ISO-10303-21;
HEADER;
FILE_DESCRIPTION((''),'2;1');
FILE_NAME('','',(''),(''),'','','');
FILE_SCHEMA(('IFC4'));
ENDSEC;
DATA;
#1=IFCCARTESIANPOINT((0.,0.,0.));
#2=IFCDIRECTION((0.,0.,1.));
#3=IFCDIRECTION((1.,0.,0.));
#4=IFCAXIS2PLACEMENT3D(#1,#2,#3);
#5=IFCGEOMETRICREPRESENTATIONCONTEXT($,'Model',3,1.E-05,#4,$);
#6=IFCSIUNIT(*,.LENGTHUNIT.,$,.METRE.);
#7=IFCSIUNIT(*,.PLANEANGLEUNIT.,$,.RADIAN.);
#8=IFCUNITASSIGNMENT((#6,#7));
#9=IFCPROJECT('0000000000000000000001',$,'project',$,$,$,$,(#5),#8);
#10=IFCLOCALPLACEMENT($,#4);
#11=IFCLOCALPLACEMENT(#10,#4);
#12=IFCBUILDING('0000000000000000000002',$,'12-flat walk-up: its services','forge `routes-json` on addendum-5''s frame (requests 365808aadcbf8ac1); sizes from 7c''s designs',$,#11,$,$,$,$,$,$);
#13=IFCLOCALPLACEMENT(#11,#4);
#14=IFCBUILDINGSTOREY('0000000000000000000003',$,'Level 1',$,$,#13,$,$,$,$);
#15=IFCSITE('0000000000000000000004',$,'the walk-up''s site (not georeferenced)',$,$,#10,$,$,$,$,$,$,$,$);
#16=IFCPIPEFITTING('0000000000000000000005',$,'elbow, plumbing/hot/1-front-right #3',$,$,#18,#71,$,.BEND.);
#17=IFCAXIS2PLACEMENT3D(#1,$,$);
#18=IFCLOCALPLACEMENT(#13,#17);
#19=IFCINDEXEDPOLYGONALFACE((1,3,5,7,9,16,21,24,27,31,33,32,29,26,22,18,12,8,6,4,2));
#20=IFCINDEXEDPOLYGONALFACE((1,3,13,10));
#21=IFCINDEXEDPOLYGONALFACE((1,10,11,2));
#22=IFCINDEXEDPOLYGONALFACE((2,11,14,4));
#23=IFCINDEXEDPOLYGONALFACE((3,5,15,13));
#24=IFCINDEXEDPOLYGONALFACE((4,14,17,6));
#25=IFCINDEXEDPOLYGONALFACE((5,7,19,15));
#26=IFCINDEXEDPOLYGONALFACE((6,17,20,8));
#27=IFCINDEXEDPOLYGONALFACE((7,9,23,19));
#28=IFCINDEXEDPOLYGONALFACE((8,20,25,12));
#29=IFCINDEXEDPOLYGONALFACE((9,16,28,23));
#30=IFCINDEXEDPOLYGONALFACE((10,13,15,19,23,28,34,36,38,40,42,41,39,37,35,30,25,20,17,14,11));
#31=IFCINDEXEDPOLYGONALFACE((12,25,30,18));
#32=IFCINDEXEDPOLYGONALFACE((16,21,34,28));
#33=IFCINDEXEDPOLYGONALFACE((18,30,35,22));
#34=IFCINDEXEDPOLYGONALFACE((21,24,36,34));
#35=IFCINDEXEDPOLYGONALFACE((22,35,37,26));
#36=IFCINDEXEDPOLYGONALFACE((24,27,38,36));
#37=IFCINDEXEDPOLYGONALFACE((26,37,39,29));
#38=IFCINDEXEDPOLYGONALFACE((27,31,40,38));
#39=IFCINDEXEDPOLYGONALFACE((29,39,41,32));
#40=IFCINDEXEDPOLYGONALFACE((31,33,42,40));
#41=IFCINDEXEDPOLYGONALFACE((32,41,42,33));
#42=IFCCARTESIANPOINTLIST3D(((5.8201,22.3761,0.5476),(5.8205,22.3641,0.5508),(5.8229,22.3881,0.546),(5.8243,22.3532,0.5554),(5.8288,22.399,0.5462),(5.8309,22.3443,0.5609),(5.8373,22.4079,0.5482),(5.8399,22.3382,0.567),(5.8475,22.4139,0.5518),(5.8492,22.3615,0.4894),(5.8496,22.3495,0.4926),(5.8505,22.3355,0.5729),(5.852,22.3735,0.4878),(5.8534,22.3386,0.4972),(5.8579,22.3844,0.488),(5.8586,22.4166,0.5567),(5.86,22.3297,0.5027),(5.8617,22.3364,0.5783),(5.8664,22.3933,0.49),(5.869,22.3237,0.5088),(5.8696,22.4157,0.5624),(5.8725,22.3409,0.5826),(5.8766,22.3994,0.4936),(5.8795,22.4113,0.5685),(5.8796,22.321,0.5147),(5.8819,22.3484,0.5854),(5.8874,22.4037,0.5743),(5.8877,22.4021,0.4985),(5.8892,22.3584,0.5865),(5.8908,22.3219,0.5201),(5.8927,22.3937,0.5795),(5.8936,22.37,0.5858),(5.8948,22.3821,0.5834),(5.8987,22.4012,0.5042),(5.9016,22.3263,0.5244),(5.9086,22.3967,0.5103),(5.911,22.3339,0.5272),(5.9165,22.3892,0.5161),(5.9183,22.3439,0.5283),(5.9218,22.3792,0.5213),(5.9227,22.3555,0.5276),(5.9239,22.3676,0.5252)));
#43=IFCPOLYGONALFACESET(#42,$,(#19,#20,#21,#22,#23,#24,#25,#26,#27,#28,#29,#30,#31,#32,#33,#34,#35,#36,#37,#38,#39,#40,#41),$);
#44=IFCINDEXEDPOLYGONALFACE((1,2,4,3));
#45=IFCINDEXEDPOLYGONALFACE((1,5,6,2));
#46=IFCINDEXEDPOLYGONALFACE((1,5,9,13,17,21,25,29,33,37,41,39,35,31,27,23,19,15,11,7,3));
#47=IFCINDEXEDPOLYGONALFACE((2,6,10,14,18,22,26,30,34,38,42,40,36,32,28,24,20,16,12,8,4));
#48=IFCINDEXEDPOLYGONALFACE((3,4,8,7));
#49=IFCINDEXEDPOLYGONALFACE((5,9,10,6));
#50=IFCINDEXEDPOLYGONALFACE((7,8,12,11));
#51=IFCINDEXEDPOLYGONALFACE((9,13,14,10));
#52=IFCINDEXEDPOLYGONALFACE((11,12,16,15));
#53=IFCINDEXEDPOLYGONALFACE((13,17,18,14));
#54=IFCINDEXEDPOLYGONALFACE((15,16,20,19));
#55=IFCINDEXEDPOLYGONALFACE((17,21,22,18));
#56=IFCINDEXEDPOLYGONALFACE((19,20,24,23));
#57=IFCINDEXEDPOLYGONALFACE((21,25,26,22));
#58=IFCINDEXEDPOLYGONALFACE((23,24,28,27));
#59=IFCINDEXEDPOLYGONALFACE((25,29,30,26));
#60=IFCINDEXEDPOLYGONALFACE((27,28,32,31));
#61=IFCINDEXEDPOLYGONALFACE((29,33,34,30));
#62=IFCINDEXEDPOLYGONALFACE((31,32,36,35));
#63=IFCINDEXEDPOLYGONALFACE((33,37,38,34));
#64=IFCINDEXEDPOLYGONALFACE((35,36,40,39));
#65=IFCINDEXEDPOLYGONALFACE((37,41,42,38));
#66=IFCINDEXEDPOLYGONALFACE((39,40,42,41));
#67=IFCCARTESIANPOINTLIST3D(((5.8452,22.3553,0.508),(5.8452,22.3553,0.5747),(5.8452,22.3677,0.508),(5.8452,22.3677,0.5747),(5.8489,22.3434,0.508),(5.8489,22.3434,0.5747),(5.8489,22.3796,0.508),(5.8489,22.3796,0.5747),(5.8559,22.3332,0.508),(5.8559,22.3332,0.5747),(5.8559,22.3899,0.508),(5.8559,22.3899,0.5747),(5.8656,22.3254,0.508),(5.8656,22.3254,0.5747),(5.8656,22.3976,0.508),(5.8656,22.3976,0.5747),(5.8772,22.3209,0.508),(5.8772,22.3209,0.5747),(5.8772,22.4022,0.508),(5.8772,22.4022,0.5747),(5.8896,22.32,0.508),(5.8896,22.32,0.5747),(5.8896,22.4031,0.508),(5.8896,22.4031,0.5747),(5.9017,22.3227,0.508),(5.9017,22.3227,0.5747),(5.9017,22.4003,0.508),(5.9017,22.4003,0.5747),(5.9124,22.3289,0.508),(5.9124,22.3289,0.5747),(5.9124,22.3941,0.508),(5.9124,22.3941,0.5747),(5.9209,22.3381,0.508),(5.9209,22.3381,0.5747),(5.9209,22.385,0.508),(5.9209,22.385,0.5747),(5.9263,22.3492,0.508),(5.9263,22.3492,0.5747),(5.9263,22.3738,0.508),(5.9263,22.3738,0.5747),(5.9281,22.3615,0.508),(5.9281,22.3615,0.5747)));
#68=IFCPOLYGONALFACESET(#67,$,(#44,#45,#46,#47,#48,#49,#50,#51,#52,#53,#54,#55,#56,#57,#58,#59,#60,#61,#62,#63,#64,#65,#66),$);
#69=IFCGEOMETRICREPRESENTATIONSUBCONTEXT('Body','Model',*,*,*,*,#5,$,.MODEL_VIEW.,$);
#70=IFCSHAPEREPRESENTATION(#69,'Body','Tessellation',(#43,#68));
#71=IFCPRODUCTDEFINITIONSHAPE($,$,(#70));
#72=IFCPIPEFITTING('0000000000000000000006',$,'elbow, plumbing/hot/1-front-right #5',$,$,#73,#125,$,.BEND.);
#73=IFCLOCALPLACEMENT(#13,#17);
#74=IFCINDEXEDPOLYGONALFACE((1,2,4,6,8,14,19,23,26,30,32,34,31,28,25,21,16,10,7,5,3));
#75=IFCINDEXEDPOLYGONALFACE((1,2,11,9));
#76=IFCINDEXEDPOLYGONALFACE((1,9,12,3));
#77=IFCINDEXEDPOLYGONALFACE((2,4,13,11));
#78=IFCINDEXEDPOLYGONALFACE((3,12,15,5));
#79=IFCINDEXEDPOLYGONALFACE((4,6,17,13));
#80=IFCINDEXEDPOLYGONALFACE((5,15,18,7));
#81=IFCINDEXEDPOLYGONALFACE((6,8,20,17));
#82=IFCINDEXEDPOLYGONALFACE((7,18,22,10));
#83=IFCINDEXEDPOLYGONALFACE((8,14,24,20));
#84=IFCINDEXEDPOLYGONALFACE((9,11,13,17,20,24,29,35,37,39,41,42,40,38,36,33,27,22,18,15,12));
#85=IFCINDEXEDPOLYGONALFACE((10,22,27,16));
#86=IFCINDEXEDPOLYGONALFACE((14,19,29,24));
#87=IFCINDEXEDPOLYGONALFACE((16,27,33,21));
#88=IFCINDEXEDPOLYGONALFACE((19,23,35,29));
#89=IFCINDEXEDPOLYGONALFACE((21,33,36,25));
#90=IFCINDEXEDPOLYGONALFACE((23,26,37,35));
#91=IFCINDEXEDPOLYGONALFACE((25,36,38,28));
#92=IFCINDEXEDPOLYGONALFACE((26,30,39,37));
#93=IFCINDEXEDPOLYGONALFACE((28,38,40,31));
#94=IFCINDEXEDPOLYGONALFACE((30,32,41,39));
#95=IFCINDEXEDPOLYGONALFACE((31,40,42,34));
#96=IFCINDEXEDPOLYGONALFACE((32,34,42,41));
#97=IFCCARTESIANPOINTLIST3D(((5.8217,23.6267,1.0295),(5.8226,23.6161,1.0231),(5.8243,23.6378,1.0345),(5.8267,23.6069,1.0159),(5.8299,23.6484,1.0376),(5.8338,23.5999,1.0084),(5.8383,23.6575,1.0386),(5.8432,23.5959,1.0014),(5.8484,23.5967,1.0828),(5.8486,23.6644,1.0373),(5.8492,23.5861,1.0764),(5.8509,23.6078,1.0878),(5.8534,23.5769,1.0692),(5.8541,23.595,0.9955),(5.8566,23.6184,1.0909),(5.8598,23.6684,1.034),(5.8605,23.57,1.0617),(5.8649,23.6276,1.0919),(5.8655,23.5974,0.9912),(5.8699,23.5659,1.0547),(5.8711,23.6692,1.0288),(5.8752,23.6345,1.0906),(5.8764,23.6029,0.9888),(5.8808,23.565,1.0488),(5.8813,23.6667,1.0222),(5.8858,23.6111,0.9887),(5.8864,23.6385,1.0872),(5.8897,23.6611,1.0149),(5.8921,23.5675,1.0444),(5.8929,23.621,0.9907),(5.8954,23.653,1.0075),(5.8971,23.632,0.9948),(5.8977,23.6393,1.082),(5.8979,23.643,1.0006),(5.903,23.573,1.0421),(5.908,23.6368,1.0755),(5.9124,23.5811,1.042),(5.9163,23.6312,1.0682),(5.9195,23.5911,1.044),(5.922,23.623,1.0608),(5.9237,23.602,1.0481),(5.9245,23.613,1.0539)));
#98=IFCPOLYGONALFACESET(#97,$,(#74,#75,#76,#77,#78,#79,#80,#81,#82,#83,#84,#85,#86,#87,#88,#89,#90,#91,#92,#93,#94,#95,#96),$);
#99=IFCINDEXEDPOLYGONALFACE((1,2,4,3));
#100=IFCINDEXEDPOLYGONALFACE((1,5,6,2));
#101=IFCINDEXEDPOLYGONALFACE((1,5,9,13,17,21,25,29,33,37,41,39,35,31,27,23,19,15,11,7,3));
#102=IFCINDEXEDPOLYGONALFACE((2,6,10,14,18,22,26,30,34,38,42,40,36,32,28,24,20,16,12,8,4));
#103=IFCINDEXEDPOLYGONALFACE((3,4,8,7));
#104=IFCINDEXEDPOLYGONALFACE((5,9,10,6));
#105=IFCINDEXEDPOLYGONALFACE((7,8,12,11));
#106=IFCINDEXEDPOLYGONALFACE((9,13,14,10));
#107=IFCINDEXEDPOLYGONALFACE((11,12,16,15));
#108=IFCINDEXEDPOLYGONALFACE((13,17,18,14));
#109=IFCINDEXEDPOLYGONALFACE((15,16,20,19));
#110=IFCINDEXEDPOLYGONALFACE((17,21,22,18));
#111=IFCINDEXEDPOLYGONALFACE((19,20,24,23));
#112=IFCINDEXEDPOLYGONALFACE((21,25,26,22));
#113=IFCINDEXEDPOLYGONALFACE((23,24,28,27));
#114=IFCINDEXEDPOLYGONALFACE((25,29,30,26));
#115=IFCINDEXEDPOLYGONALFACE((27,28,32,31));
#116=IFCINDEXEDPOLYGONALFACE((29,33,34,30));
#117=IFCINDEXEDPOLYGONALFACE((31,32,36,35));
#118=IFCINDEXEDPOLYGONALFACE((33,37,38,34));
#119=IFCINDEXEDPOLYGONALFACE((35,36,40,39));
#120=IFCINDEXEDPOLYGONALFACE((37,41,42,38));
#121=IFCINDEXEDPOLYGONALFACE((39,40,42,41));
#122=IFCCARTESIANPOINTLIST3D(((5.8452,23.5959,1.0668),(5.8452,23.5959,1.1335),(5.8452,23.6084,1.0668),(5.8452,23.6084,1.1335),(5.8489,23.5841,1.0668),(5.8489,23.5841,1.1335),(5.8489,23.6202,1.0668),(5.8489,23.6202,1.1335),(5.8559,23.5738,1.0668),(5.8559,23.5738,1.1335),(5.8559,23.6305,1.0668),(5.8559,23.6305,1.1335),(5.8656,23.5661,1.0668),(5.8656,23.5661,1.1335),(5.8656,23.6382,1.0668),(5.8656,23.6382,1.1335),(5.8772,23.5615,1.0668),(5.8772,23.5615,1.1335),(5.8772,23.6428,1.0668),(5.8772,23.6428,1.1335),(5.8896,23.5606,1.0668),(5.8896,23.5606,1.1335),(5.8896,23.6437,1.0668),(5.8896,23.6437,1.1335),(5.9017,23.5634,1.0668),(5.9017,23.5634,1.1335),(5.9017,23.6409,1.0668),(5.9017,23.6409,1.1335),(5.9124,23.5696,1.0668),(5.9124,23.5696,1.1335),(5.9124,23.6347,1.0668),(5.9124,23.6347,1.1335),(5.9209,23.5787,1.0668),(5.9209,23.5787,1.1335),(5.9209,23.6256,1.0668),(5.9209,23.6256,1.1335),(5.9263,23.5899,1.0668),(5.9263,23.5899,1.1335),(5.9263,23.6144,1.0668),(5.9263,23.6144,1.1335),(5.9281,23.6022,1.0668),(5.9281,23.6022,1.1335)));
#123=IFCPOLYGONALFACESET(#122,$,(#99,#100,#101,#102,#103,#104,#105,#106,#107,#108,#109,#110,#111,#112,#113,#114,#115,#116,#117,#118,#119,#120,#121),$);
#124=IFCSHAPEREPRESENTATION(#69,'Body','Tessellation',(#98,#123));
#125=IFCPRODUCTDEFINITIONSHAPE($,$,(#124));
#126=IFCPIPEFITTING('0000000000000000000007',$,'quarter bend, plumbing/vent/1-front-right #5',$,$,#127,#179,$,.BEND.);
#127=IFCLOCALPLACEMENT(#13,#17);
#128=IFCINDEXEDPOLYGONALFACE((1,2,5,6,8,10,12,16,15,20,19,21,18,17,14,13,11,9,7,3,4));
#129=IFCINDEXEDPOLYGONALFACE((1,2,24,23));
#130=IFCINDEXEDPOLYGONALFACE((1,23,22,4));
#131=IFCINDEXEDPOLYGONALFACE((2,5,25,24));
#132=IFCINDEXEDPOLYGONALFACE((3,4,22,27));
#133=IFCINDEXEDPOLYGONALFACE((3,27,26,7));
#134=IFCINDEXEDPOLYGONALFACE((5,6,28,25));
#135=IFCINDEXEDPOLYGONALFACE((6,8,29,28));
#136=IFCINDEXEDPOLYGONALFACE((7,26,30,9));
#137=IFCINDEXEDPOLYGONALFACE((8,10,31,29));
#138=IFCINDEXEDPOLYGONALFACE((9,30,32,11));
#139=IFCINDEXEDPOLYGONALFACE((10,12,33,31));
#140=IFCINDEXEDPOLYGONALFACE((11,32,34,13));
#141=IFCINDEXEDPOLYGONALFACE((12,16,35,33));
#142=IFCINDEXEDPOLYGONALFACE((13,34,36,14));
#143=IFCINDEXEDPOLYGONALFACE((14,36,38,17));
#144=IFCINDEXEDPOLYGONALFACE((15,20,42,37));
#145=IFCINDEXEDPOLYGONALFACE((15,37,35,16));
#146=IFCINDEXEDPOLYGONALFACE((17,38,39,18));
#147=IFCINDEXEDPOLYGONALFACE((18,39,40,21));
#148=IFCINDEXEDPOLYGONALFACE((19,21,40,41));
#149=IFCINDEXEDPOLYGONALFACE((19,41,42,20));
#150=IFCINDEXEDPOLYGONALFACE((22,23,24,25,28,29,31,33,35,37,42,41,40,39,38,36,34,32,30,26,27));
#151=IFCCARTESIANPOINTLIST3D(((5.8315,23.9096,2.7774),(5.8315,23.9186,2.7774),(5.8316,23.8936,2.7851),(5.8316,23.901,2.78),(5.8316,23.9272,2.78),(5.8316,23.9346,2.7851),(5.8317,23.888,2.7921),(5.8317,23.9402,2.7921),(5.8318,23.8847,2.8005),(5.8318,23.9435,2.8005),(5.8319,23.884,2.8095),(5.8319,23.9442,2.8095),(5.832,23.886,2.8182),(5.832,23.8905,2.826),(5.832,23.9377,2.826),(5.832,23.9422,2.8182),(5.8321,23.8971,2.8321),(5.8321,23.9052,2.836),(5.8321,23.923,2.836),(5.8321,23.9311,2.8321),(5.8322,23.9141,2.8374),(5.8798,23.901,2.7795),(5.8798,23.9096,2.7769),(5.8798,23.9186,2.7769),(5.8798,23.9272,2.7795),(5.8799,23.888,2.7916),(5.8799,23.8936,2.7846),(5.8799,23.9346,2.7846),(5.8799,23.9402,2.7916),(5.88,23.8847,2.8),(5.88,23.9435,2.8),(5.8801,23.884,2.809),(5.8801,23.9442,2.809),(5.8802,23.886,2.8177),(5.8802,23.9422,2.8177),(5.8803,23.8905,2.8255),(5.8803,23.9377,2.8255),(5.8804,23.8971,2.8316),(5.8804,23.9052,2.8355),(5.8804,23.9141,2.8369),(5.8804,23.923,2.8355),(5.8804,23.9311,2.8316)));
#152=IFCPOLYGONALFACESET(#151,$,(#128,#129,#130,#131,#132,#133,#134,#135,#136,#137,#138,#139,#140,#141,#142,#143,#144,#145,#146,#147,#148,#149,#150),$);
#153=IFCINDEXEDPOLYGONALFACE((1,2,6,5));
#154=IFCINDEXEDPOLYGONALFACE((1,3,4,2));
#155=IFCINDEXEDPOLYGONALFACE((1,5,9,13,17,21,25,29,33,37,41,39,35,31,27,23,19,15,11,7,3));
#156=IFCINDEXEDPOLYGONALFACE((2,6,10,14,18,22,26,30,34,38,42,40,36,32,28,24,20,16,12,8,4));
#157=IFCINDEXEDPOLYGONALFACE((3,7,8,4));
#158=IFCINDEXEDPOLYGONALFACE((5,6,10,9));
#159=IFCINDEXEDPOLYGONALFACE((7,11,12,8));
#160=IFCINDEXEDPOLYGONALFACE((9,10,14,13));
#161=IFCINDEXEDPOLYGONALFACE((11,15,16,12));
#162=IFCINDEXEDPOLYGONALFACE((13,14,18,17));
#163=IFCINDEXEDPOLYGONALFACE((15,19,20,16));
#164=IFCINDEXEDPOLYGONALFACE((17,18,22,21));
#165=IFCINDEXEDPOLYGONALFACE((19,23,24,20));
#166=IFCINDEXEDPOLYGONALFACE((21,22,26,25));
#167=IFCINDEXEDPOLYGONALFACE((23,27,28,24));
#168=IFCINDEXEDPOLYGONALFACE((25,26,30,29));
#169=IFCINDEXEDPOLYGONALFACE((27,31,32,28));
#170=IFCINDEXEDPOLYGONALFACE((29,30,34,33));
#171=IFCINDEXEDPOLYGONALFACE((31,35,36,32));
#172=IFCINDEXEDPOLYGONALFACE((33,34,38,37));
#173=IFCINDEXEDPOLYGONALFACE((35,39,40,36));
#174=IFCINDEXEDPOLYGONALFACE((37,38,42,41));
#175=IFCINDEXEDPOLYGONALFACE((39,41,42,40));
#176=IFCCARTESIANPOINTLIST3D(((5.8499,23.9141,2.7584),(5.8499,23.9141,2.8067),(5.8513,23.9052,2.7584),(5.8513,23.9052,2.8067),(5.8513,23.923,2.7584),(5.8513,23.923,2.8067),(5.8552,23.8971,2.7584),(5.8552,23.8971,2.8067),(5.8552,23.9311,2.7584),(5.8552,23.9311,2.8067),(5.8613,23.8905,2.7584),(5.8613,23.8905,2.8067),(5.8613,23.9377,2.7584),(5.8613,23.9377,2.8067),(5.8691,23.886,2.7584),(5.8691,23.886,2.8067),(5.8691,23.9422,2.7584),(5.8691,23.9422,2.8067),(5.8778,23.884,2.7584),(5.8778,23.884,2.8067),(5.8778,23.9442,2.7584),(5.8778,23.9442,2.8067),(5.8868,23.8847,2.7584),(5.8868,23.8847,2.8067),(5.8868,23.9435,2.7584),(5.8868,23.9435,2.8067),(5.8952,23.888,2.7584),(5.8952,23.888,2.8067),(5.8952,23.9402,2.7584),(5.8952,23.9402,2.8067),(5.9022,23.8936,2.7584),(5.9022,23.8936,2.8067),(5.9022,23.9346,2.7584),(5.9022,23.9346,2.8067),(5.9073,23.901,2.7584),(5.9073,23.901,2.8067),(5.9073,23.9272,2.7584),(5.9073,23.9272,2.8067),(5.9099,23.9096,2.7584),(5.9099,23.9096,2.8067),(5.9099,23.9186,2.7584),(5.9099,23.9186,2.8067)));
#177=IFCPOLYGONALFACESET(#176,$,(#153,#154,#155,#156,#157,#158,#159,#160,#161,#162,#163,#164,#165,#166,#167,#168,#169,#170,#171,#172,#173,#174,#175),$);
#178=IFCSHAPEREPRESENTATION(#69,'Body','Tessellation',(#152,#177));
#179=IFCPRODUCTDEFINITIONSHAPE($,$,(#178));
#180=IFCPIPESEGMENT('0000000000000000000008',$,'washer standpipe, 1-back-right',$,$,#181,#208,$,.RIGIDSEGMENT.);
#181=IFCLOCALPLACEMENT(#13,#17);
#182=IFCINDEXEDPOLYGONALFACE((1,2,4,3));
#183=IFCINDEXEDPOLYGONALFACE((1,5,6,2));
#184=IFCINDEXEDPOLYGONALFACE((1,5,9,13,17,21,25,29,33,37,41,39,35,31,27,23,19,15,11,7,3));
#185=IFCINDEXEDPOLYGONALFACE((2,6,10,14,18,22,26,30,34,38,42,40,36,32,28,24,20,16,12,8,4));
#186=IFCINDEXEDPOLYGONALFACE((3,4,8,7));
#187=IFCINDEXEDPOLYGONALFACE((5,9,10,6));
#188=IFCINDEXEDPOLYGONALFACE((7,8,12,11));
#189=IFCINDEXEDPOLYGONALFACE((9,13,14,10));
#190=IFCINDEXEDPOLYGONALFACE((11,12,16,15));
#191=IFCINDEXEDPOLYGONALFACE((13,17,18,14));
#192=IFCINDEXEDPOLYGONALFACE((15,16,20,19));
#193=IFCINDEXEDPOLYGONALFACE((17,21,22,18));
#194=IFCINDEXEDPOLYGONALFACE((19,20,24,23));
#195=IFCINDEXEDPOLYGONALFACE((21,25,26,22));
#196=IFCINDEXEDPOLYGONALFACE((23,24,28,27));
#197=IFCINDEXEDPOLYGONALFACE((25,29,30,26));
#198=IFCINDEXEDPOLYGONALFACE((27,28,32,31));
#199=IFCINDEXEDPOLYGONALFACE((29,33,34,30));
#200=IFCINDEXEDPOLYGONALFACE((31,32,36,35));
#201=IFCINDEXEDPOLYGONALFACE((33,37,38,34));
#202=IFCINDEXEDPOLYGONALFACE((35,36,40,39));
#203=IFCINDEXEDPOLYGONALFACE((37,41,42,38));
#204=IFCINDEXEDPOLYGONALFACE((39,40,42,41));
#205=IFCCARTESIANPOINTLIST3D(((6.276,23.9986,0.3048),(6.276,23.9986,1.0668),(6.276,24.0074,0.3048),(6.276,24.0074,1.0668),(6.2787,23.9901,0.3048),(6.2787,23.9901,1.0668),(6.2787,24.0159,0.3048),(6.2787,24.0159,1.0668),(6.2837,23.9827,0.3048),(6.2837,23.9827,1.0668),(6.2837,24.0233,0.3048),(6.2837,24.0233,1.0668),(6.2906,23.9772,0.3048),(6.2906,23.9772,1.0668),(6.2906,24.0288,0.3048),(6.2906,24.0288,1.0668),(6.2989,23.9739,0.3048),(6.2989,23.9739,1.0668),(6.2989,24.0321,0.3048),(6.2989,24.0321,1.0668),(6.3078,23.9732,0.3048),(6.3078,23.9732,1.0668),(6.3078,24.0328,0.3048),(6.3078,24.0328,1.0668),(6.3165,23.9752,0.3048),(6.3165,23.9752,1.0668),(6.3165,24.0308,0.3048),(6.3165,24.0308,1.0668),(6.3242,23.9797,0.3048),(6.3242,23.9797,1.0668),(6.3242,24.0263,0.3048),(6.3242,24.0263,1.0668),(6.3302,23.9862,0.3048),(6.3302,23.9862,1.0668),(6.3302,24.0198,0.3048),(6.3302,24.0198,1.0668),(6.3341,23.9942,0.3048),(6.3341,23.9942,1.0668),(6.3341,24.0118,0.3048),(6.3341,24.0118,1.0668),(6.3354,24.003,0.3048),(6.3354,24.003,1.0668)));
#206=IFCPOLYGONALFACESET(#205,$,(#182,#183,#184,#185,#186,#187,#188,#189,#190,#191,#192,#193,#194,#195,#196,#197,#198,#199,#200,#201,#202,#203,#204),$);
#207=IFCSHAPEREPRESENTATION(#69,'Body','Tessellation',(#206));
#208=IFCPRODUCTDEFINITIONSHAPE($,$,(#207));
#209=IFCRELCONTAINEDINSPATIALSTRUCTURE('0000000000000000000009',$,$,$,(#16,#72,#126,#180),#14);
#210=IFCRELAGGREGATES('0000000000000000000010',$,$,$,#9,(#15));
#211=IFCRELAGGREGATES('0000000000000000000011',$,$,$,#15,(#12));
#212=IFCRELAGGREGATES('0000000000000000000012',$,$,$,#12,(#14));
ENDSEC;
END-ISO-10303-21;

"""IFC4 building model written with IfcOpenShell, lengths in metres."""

from ifc_helpers import new_model, entity, si_unit, frame, origin_with_axes, place, context, subcontext, project, spatial, element, save


model = new_model("IFC4")

# Units and contexts
model_context = context("Model", 3, precision=1e-05, world=origin_with_axes())
body_context = subcontext(model_context, "Body", "Model", "MODEL_VIEW")
ifc_project = project(units=[si_unit("LENGTHUNIT", "METRE"), si_unit("PLANEANGLEUNIT", "RADIAN")], contexts=[model_context])

# Site, building, storey
site_placement = place(None, origin_with_axes())
site = spatial("IfcSite", under=ifc_project, at=site_placement, Name="the walk-up's site (not georeferenced)")
building_placement = place(site_placement, origin_with_axes())
building = spatial("IfcBuilding", under=site, at=building_placement, Name="12-flat walk-up: its services", Description="forge `routes-json` on addendum-5's frame (requests 365808aadcbf8ac1); sizes from 7c's designs")
storey_placement = place(building_placement, origin_with_axes())
storey = spatial("IfcBuildingStorey", under=building, at=storey_placement, Name="Level 1")

# Pipe fittings
pipe_fitting_1_placement = place(storey_placement, frame((5.8574, 22.3761, 0.5662), z_axis=(0.0, 0.0, 1.0), x_axis=(1.0, 0.0, 0.0)))
element("IfcPipeFitting", 1, at=pipe_fitting_1_placement, inside=storey, Name="elbow, plumbing/hot/1-front-right #3", PredefinedType="BEND", context=body_context, shape_type="AdvancedSweptSolid", body=[
    entity("IfcSweptDiskSolid", entity("IfcPolyline", [entity("IfcCartesianPoint", [0.0, 0.0, 0.0]), entity("IfcCartesianPoint", [0.0291, -0.0145, -0.0582])]), 0.0417),
    entity("IfcSweptDiskSolid", entity("IfcPolyline", [entity("IfcCartesianPoint", [0.0291, -0.0145, -0.0582]), entity("IfcCartesianPoint", [0.0291, -0.0145, 0.0085])]), 0.0417),
])
pipe_fitting_2_placement = place(storey_placement, frame((5.8598, 23.6321, 1.0135), z_axis=(0.0, 0.0, 1.0), x_axis=(1.0, 0.0, 0.0)))
element("IfcPipeFitting", 2, at=pipe_fitting_2_placement, inside=storey, Name="elbow, plumbing/hot/1-front-right #5", PredefinedType="BEND", context=body_context, shape_type="AdvancedSweptSolid", body=[
    entity("IfcSweptDiskSolid", entity("IfcPolyline", [entity("IfcCartesianPoint", [0.0, 0.0, 0.0]), entity("IfcCartesianPoint", [0.0266, -0.03, 0.0533])]), 0.0417),
    entity("IfcSweptDiskSolid", entity("IfcPolyline", [entity("IfcCartesianPoint", [0.0266, -0.03, 0.0533]), entity("IfcCartesianPoint", [0.0266, -0.03, 0.1199])]), 0.0417),
])
pipe_fitting_3_placement = place(storey_placement, frame((5.8318, 23.9141, 2.8072), z_axis=(0.0, 0.0, 1.0), x_axis=(1.0, 0.0, 0.0)))
element("IfcPipeFitting", 3, at=pipe_fitting_3_placement, inside=storey, Name="quarter bend, plumbing/vent/1-front-right #5", PredefinedType="BEND", context=body_context, shape_type="AdvancedSweptSolid", body=[
    entity("IfcSweptDiskSolid", entity("IfcPolyline", [entity("IfcCartesianPoint", [0.0, 0.0, 0.0]), entity("IfcCartesianPoint", [0.0483, 0.0, -0.0005])]), 0.0302),
    entity("IfcSweptDiskSolid", entity("IfcPolyline", [entity("IfcCartesianPoint", [0.0483, 0.0, -0.0005]), entity("IfcCartesianPoint", [0.0483, 0.0, -0.0488])]), 0.0302),
])

# Pipe segment
for number, where, z_axis, x_axis, name in (
    (4, (6.3056, 24.003, 0.3048), (0.0, 0.0, 1.0), (1.0, 0.0, 0.0), "washer standpipe, 1-back-right"),
):
    element("IfcPipeSegment", number, at=place(storey_placement, frame(where, z_axis=z_axis, x_axis=x_axis)), inside=storey, Name=name, PredefinedType="RIGIDSEGMENT", context=body_context, shape_type="AdvancedSweptSolid", body=[
        entity("IfcSweptDiskSolid", entity("IfcPolyline", [entity("IfcCartesianPoint", [0.0, 0.0, 0.0]), entity("IfcCartesianPoint", [0.0, 0.0, 0.762])]), 0.0298),
    ])

save(model, "model.ifc")
